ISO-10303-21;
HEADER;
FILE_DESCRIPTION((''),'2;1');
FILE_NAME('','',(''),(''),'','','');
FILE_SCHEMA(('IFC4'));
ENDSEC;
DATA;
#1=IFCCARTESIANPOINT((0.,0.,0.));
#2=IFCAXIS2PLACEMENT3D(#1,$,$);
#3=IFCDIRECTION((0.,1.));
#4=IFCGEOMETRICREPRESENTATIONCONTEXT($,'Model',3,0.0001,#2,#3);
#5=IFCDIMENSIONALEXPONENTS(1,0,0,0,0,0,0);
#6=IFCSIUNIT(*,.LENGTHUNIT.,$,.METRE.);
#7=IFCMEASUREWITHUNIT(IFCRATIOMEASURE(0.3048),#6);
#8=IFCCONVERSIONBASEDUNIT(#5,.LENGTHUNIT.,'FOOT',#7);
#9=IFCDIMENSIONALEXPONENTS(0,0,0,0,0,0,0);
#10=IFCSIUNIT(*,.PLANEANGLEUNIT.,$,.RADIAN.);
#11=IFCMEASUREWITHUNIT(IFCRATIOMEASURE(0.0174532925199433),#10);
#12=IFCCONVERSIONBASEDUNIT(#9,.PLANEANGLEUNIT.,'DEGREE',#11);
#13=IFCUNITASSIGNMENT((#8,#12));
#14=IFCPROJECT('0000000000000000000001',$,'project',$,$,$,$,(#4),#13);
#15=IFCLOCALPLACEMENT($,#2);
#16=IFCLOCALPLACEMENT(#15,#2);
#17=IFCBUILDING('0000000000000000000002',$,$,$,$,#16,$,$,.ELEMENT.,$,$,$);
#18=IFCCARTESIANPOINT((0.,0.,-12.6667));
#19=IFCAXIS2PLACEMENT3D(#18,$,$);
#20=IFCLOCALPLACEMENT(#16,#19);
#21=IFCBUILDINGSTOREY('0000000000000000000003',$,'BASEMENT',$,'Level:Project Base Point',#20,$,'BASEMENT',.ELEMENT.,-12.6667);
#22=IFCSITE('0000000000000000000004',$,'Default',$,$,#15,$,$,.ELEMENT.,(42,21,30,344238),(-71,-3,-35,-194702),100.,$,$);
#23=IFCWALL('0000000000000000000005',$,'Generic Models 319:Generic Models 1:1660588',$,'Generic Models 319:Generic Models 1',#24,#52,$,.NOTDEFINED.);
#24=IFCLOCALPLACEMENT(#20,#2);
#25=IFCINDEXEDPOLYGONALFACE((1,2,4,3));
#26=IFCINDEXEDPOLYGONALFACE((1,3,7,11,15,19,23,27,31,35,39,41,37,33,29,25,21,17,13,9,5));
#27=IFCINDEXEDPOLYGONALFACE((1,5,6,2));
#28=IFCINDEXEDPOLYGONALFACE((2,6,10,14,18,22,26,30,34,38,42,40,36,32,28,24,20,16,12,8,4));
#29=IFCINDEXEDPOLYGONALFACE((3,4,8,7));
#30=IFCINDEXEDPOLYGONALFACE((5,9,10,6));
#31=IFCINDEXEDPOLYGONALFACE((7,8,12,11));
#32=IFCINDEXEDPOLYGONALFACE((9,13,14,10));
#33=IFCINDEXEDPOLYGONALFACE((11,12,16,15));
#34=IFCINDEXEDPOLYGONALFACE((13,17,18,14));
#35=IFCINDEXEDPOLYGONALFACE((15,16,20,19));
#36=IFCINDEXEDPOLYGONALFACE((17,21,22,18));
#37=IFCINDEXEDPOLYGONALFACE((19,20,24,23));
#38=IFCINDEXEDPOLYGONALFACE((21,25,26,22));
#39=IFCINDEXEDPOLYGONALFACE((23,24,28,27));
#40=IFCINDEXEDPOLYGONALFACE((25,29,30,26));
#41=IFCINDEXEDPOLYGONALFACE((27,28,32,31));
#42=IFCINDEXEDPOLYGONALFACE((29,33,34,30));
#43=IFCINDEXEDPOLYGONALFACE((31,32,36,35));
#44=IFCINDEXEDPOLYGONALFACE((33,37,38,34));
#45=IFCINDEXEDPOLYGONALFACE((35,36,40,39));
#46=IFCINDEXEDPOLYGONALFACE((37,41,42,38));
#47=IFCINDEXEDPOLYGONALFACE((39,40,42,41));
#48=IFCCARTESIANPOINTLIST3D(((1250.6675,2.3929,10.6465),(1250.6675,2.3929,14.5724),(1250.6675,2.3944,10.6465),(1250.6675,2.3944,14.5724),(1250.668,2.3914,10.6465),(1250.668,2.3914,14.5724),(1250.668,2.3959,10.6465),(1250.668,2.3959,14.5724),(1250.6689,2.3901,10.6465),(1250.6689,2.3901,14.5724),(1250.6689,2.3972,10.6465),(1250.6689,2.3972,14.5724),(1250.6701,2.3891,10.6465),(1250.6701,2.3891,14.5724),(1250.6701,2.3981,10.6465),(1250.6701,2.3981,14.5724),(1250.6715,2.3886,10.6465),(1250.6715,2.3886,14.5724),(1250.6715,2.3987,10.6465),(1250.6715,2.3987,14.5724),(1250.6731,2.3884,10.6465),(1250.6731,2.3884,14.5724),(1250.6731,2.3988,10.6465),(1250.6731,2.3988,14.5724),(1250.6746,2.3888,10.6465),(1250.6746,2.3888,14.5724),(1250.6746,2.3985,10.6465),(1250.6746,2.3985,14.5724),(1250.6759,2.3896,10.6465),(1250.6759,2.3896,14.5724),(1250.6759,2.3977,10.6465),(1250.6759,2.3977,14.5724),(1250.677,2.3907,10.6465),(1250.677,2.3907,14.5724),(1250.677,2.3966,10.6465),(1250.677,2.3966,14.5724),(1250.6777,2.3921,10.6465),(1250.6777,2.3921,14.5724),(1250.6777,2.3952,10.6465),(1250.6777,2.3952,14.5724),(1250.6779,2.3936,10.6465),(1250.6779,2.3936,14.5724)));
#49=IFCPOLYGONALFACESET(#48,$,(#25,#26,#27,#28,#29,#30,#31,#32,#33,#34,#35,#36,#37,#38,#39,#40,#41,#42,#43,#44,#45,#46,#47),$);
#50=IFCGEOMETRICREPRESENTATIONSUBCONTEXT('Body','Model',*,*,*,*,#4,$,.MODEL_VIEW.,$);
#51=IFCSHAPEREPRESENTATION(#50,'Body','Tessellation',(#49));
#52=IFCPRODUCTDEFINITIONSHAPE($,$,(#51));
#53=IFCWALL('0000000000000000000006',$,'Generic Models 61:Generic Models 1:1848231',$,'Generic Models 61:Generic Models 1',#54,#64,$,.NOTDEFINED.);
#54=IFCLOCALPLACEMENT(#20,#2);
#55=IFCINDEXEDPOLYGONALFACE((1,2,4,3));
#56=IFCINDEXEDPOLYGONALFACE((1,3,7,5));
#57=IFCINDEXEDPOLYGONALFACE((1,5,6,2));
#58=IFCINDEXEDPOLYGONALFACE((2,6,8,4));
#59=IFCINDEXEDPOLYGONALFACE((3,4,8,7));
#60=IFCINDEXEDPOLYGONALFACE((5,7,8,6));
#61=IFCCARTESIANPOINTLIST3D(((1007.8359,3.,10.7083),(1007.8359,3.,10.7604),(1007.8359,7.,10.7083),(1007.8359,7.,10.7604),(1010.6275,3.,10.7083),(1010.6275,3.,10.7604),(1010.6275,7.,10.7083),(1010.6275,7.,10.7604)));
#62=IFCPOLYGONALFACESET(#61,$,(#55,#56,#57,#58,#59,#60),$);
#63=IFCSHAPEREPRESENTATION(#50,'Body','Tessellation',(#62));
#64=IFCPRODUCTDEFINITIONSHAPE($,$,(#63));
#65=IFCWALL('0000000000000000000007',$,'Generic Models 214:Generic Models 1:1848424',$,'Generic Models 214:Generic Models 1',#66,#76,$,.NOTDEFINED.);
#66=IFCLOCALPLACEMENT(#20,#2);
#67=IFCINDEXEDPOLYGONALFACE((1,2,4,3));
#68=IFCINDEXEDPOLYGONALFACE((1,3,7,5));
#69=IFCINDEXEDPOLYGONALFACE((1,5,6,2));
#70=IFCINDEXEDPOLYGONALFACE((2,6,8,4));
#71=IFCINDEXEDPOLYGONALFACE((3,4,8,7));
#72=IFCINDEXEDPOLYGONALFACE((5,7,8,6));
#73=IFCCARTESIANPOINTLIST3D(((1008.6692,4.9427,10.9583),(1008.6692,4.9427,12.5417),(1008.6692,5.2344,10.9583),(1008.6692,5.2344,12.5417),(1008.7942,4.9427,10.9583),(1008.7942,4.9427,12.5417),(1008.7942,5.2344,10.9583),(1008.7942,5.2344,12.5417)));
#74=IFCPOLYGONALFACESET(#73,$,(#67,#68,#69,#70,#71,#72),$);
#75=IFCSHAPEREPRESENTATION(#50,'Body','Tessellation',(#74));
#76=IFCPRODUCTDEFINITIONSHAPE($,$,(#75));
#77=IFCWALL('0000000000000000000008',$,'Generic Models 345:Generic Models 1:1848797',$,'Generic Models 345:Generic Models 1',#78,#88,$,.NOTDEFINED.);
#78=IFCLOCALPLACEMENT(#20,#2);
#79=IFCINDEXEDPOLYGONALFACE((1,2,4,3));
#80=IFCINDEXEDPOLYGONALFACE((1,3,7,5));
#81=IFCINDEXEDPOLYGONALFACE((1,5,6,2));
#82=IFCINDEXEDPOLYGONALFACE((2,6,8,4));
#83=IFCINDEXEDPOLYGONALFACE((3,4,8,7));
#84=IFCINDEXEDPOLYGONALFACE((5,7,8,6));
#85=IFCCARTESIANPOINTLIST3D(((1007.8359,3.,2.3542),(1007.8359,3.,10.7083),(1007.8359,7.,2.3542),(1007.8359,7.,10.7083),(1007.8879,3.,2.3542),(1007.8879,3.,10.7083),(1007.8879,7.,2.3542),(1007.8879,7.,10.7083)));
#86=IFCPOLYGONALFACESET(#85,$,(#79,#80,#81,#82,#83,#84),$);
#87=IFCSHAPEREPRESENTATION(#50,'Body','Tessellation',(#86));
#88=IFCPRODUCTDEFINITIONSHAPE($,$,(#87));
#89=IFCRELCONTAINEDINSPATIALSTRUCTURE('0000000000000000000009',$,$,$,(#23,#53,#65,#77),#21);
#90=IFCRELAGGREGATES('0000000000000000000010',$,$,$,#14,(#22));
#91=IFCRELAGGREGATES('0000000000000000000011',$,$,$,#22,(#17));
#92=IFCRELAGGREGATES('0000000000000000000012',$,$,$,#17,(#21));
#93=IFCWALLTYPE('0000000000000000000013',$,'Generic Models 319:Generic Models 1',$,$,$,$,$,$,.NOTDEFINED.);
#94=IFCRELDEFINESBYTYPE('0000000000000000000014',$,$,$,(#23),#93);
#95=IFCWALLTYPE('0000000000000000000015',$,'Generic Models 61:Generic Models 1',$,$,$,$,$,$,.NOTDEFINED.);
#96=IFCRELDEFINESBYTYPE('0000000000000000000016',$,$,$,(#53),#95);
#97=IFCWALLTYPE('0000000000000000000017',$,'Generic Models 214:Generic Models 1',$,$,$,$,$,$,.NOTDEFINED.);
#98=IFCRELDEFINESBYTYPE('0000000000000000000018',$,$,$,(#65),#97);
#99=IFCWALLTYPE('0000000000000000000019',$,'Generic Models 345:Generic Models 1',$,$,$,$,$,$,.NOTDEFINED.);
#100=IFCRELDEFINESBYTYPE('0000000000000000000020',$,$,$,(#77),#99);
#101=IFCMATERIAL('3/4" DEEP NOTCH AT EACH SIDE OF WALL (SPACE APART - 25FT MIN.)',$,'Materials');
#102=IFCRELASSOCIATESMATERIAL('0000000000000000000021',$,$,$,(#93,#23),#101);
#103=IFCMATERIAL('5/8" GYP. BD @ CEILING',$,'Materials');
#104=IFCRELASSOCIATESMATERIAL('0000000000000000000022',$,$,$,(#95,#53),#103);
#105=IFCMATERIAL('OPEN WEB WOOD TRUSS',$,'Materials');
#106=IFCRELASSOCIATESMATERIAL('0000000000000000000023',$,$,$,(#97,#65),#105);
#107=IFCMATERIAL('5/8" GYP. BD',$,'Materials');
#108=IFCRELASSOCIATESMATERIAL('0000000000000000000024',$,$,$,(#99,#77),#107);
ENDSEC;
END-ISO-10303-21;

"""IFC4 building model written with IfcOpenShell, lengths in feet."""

from ifc_helpers import new_model, entity, si_unit, converted_unit, direction, frame, frame_2d, origin, origin_2d_with_axis, place, context, subcontext, project, spatial, rectangle, circle, extrude, material, type_object, element, save


model = new_model("IFC4")

# Units and contexts
model_context = context("Model", 3, precision=0.0001, world=origin(), true_north=direction((0.0, 1.0)))
body_context = subcontext(model_context, "Body", "Model", "MODEL_VIEW")
ifc_project = project(units=[converted_unit("LENGTHUNIT", "FOOT", entity("IfcRatioMeasure", 0.3048), si_unit("LENGTHUNIT", "METRE"), dimensions=[1, 0, 0, 0, 0, 0, 0]), converted_unit("PLANEANGLEUNIT", "DEGREE", entity("IfcRatioMeasure", 0.0174532925199433), si_unit("PLANEANGLEUNIT", "RADIAN"), dimensions=[0, 0, 0, 0, 0, 0, 0])], contexts=[model_context])

# Site, building, storey
site_placement = place(None, origin())
site = spatial("IfcSite", under=ifc_project, at=site_placement, Name="Default", CompositionType="ELEMENT", RefLatitude=(42, 21, 30, 344238), RefLongitude=(-71, -3, -35, -194702), RefElevation=100.0)
building_placement = place(site_placement, origin())
building = spatial("IfcBuilding", under=site, at=building_placement, CompositionType="ELEMENT")
storey_placement = place(building_placement, frame((0.0, 0.0, -12.6667)))
storey = spatial("IfcBuildingStorey", under=building, at=storey_placement, Name="BASEMENT", ObjectType="Level:Project Base Point", LongName="BASEMENT", CompositionType="ELEMENT", Elevation=-12.6667)

# Walls
ifc_material_1 = material(Name="3/4\" DEEP NOTCH AT EACH SIDE OF WALL (SPACE APART - 25FT MIN.)", Category="Materials")
wall_type_1 = type_object("IfcWallType", Name="Generic Models 319:Generic Models 1", PredefinedType="NOTDEFINED", material=ifc_material_1)
wall_1_placement = place(storey_placement, frame((1250.6675, 2.3884, 10.6465), z_axis=(0.0, 0.0, 1.0), x_axis=(0.0, 1.0, 0.0)))
element("IfcWall", 1, at=wall_1_placement, inside=storey, type_object=wall_type_1, material=ifc_material_1, Name="Generic Models 319:Generic Models 1:1660588", ObjectType="Generic Models 319:Generic Models 1", PredefinedType="NOTDEFINED", context=body_context, shape_type="SweptSolid", body=[
    extrude(circle(Radius=0.0052, at=origin_2d_with_axis()), frame((0.0052, -0.0052, 0.0), z_axis=(0.0, 0.0, 1.0), x_axis=(0.0, -1.0, 0.0)), (0.0, 0.0, 1.0), 3.9258),
])
ifc_material_2 = material(Name="5/8\" GYP. BD @ CEILING", Category="Materials")
wall_type_2 = type_object("IfcWallType", Name="Generic Models 61:Generic Models 1", PredefinedType="NOTDEFINED", material=ifc_material_2)
wall_2_placement = place(storey_placement, frame((1007.8359, 3.0, 10.7083), z_axis=(0.0, 0.0, 1.0), x_axis=(0.0, 1.0, 0.0)))
element("IfcWall", 2, at=wall_2_placement, inside=storey, type_object=wall_type_2, material=ifc_material_2, Name="Generic Models 61:Generic Models 1:1848231", ObjectType="Generic Models 61:Generic Models 1", PredefinedType="NOTDEFINED", context=body_context, shape_type="SweptSolid", body=[
    extrude(rectangle(XDim=4.0, YDim=2.7917, at=frame_2d((0.0, 0.0), x_axis=(1.0, 0.0))), frame((2.0, -1.3958, 0.0)), (0.0, 0.0, 1.0), 0.0521),
])
ifc_material_3 = material(Name="OPEN WEB WOOD TRUSS", Category="Materials")
wall_type_3 = type_object("IfcWallType", Name="Generic Models 214:Generic Models 1", PredefinedType="NOTDEFINED", material=ifc_material_3)
wall_3_placement = place(storey_placement, frame((1008.6692, 4.9427, 10.9583), z_axis=(0.0, 0.0, 1.0), x_axis=(0.0, 1.0, 0.0)))
element("IfcWall", 3, at=wall_3_placement, inside=storey, type_object=wall_type_3, material=ifc_material_3, Name="Generic Models 214:Generic Models 1:1848424", ObjectType="Generic Models 214:Generic Models 1", PredefinedType="NOTDEFINED", context=body_context, shape_type="SweptSolid", body=[
    extrude(rectangle(XDim=0.2917, YDim=0.125, at=frame_2d((0.0, 0.0), x_axis=(1.0, 0.0))), frame((0.1458, -0.0625, 0.0)), (0.0, 0.0, 1.0), 1.5833),
])
ifc_material_4 = material(Name="5/8\" GYP. BD", Category="Materials")
wall_type_4 = type_object("IfcWallType", Name="Generic Models 345:Generic Models 1", PredefinedType="NOTDEFINED", material=ifc_material_4)
wall_4_placement = place(storey_placement, frame((1007.8359, 3.0, 2.3542), z_axis=(0.0, 0.0, 1.0), x_axis=(0.0, 1.0, 0.0)))
element("IfcWall", 4, at=wall_4_placement, inside=storey, type_object=wall_type_4, material=ifc_material_4, Name="Generic Models 345:Generic Models 1:1848797", ObjectType="Generic Models 345:Generic Models 1", PredefinedType="NOTDEFINED", context=body_context, shape_type="SweptSolid", body=[
    extrude(rectangle(XDim=4.0, YDim=0.0521, at=frame_2d((0.0, 0.0), x_axis=(1.0, 0.0))), frame((2.0, -0.026, 0.0)), (0.0, 0.0, 1.0), 8.3542),
])

save(model, "model.ifc")
